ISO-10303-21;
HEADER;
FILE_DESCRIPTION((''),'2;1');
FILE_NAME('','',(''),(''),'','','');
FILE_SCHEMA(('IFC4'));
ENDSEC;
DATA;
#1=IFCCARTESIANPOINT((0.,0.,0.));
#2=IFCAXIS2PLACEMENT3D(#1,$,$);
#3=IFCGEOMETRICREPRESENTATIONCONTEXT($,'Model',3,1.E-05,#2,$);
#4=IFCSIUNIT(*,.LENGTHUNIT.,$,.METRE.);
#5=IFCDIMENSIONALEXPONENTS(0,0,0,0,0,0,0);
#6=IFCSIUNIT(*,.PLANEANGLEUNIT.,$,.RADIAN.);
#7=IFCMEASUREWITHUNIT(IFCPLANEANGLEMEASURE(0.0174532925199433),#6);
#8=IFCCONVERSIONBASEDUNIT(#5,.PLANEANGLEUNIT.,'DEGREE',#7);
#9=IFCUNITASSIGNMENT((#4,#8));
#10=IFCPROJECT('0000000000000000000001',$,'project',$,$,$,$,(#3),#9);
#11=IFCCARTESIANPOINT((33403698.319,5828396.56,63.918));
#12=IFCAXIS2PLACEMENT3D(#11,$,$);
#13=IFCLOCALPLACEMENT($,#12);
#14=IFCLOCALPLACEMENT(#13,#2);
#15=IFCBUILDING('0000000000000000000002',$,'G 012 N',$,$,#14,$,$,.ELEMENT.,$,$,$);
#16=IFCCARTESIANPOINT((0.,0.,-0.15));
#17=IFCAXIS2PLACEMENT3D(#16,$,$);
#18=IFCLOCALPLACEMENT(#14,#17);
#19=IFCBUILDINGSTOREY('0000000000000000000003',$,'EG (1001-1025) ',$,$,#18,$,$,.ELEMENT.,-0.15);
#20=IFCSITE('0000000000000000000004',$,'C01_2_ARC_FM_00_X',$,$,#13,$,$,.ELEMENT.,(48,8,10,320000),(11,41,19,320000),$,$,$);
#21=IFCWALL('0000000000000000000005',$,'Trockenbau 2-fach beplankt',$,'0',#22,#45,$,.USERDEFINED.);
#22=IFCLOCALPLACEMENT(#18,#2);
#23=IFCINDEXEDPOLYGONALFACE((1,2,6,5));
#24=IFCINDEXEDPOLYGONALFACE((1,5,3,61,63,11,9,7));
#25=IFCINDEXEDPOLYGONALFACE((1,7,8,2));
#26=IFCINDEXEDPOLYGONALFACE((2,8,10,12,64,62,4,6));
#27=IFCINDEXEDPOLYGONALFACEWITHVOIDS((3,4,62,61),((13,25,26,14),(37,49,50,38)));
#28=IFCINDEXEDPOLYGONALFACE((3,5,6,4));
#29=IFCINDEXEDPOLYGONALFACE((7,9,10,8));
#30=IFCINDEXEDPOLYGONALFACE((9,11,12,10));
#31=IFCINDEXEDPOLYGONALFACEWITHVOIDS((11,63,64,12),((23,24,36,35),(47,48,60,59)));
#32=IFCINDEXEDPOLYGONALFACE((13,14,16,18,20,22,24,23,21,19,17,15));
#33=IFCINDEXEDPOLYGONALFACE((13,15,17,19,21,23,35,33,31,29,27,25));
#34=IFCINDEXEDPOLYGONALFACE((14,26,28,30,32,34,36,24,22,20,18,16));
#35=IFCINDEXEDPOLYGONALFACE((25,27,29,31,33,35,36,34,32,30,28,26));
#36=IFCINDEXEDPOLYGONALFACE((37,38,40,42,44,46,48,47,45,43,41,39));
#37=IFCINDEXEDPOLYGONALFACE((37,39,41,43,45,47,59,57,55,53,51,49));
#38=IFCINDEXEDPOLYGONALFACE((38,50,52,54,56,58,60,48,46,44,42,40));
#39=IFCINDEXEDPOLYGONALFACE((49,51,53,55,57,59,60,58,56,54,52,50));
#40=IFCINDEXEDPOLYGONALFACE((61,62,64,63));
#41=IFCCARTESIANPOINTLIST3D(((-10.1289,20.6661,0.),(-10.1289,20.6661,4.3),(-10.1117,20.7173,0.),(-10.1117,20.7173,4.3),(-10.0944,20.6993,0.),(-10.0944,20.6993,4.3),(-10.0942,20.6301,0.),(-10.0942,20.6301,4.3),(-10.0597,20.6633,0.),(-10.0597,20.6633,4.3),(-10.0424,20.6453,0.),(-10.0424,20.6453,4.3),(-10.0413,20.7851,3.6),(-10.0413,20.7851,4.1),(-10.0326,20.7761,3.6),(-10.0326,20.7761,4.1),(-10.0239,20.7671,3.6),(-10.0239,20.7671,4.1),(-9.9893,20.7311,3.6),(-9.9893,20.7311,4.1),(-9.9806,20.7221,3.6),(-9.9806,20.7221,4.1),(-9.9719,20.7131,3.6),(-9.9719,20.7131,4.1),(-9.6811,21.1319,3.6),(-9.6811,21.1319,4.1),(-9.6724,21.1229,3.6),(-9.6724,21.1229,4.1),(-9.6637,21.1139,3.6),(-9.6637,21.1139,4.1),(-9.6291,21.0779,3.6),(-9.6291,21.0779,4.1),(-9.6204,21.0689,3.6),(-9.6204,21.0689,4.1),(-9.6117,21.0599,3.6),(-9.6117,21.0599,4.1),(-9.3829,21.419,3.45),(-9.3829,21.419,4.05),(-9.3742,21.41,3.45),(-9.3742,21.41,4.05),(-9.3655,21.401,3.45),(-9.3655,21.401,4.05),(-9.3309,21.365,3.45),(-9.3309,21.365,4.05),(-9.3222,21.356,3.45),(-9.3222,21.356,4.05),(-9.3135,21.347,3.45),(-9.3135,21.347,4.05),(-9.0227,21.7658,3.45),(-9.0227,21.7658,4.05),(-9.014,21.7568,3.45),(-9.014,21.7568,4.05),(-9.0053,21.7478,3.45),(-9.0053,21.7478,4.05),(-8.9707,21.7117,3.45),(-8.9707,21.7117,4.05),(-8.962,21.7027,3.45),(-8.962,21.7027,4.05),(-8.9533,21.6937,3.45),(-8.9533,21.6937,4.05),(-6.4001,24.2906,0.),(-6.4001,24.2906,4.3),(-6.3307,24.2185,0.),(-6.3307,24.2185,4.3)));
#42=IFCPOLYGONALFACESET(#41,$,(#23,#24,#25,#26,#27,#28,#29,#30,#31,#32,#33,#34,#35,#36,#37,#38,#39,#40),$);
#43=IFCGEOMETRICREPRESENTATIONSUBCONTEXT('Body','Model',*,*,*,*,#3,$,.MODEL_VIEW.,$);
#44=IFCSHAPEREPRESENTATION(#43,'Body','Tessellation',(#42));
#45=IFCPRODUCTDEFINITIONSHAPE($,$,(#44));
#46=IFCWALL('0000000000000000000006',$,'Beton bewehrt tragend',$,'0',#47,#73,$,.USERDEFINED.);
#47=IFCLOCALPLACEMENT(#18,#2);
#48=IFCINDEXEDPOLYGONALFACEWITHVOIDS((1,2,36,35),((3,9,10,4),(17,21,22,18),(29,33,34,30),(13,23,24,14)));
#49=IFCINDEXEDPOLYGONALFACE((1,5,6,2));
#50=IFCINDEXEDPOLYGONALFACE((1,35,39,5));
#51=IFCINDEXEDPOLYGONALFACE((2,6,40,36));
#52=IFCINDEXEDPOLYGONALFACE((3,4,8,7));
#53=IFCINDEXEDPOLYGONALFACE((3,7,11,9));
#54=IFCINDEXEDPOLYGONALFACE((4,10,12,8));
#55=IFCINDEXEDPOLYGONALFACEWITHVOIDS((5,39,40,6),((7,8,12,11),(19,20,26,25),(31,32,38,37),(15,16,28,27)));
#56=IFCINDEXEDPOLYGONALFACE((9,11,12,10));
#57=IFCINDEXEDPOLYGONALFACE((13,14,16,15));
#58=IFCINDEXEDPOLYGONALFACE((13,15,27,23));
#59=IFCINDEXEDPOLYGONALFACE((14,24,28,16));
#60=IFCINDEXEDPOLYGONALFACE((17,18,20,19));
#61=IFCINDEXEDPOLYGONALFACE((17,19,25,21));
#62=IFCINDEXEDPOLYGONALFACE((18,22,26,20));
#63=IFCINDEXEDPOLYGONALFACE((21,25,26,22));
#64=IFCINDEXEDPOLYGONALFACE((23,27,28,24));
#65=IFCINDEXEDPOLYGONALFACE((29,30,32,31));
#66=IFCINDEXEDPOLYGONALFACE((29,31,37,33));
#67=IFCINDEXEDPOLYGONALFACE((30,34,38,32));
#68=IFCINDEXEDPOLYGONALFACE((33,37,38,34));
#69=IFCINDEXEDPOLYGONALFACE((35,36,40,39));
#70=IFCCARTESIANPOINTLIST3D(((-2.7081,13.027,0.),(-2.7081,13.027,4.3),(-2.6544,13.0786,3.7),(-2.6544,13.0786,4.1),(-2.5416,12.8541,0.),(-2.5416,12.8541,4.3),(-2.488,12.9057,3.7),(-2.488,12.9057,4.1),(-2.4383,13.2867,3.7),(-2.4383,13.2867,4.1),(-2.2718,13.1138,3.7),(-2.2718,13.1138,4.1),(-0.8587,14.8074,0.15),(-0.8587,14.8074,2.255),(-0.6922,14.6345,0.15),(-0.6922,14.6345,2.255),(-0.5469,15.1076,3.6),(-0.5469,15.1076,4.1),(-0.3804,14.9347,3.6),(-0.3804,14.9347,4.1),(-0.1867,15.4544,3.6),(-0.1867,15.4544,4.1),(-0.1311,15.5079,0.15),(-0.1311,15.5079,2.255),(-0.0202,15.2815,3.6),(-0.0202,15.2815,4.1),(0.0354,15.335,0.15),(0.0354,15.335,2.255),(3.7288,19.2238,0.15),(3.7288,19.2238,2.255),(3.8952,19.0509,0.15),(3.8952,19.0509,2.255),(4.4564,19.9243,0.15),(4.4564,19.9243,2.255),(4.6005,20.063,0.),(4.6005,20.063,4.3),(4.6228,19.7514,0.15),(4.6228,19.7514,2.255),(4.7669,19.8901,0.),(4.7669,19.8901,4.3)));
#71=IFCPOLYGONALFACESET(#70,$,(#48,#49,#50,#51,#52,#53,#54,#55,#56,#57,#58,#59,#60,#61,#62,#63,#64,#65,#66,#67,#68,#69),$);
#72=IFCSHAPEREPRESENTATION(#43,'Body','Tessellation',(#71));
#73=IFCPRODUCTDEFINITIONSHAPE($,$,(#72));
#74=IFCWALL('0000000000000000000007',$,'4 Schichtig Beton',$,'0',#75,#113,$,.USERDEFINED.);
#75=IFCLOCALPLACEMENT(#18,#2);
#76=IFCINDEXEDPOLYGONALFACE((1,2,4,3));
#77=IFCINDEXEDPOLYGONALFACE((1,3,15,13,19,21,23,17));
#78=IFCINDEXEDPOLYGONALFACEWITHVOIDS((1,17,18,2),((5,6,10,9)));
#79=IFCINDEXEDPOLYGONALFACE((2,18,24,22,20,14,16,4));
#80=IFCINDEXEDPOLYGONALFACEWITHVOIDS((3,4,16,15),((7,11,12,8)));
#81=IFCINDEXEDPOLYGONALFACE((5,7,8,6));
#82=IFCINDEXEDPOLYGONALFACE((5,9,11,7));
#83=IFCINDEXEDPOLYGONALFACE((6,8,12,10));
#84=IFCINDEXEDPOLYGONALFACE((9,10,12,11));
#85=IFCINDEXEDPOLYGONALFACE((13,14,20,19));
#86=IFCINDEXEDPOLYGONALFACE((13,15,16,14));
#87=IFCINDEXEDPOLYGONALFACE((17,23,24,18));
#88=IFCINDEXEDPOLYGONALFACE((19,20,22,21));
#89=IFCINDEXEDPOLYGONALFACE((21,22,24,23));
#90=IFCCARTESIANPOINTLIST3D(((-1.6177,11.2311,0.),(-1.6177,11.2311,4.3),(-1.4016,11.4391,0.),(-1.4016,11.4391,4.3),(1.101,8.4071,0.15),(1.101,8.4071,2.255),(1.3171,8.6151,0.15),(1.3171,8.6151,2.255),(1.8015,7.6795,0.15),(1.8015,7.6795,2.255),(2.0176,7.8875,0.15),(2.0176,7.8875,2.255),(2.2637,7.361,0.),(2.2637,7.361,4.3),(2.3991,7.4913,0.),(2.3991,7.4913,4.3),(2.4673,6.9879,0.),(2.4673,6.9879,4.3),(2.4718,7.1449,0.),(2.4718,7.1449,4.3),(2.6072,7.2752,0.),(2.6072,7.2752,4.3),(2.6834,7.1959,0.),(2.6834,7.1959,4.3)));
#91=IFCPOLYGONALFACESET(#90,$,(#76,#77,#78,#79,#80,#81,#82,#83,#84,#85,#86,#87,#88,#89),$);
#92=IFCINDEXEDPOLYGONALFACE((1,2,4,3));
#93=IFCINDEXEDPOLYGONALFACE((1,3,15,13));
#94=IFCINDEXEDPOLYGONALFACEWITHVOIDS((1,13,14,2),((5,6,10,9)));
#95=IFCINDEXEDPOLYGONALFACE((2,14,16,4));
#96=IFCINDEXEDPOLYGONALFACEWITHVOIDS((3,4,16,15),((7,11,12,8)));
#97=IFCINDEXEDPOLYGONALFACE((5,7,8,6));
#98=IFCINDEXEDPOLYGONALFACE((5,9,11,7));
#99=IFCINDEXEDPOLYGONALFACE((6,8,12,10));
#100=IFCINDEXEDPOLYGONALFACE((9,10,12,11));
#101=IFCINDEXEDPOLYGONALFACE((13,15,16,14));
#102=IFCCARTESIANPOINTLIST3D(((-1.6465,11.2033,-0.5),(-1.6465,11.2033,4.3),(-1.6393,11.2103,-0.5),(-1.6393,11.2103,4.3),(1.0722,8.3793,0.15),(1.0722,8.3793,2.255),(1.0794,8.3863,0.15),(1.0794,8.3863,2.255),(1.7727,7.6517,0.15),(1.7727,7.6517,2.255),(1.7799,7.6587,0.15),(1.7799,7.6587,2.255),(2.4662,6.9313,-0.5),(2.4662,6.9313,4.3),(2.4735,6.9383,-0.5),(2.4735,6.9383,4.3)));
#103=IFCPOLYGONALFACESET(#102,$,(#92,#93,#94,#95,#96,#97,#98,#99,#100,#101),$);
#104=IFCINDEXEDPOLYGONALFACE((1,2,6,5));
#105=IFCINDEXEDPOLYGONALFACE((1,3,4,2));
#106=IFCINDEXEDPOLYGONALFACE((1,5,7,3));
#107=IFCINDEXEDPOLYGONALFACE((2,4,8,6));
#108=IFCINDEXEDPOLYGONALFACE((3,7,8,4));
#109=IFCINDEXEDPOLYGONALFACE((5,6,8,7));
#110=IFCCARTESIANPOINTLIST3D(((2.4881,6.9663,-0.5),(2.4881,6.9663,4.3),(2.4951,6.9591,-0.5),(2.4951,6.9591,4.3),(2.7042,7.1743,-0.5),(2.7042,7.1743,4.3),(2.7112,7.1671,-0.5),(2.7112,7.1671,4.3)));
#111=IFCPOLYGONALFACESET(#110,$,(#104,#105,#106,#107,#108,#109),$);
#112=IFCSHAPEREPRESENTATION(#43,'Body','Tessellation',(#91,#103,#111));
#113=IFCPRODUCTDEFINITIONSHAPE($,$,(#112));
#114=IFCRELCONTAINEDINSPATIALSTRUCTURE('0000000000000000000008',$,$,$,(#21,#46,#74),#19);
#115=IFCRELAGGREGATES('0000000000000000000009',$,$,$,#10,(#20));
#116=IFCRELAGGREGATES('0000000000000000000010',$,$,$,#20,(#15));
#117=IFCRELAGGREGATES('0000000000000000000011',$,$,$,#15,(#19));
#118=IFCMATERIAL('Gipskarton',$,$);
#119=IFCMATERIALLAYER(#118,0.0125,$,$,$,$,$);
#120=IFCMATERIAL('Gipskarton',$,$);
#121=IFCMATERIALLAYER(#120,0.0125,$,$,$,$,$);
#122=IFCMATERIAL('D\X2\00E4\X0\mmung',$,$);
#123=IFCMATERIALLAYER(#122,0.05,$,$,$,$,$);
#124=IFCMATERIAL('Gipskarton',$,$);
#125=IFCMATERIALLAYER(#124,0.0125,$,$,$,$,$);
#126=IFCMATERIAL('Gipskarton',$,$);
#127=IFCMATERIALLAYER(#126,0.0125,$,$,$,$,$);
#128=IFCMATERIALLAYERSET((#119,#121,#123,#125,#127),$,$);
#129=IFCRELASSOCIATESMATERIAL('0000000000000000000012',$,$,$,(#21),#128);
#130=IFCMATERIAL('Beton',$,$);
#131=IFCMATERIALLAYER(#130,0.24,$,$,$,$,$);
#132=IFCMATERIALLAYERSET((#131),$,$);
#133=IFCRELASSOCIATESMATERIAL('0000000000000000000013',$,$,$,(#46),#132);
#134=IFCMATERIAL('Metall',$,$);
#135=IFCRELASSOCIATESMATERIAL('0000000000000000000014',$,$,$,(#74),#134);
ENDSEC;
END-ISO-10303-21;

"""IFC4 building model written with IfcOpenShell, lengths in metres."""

from ifc_helpers import new_model, entity, si_unit, converted_unit, frame, frame_2d, origin, origin_with_axes, place, context, subcontext, project, spatial, polyline, rectangle, outline, extrude, clip, bounded_halfspace, material, layer, layer_set, layer_usage, element, save


model = new_model("IFC4")

# Units and contexts
model_context = context("Model", 3, precision=1e-05, world=origin())
body_context = subcontext(model_context, "Body", "Model", "MODEL_VIEW")
ifc_project = project(units=[si_unit("LENGTHUNIT", "METRE"), converted_unit("PLANEANGLEUNIT", "DEGREE", entity("IfcPlaneAngleMeasure", 0.0174532925199433), si_unit("PLANEANGLEUNIT", "RADIAN"), dimensions=[0, 0, 0, 0, 0, 0, 0])], contexts=[model_context])

# Site, building, storey
site_placement = place(None, frame((33403698.319, 5828396.56, 63.918)))
site = spatial("IfcSite", under=ifc_project, at=site_placement, Name="C01_2_ARC_FM_00_X", CompositionType="ELEMENT", RefLatitude=(48, 8, 10, 320000), RefLongitude=(11, 41, 19, 320000))
building_placement = place(site_placement, origin())
building = spatial("IfcBuilding", under=site, at=building_placement, Name="G 012 N", CompositionType="ELEMENT")
storey_placement = place(building_placement, frame((0.0, 0.0, -0.15)))
storey = spatial("IfcBuildingStorey", under=building, at=storey_placement, Name="EG (1001-1025) ", CompositionType="ELEMENT", Elevation=-0.15)

# Walls, openings
ifc_material_1 = material(Name="Gipskarton")
ifc_layer_1 = layer(ifc_material_1, 0.0125)
ifc_material_2 = material(Name="Gipskarton")
ifc_layer_2 = layer(ifc_material_2, 0.0125)
ifc_material_3 = material(Name="Dämmung")
ifc_layer_3 = layer(ifc_material_3, 0.05)
ifc_material_4 = material(Name="Gipskarton")
ifc_layer_4 = layer(ifc_material_4, 0.0125)
ifc_material_5 = material(Name="Gipskarton")
ifc_layer_5 = layer(ifc_material_5, 0.0125)
ifc_layer_set_1 = layer_set([ifc_layer_1, ifc_layer_2, ifc_layer_3, ifc_layer_4, ifc_layer_5])
ifc_layer_usage_1 = layer_usage(ifc_layer_set_1, "AXIS2", "POSITIVE", 0.0)
wall_1_placement = place(storey_placement, frame((-10.0424, 20.6453, 0.0), z_axis=(0.0, 0.0, 1.0), x_axis=(0.720408, 0.693551, 0.0)))
wall_1 = element("IfcWall", 1, at=wall_1_placement, inside=storey, material=ifc_layer_usage_1, Name="Trockenbau 2-fach beplankt", ObjectType="0", PredefinedType="USERDEFINED", context=body_context, shape_type="SweptSolid", body=[
    extrude(outline(polyline([(0.0728, 0.0509), (0.0728, 0.0259), (0.025, 0.0259), (0.025, -0.0241), (0.0728, -0.0241), (0.0728, -0.0491), (5.225, -0.0491), (5.225, 0.0509), (0.0728, 0.0509)])), frame((-0.0728, 0.0491, 0.0), z_axis=(0.0, 0.0, 1.0), x_axis=(1.0, 0.0, 0.0)), (0.0, 0.0, 1.0), 4.3),
])
opening_1_placement = place(wall_1_placement, frame((1.5117, 0.1, 3.45), z_axis=(0.0, -1.0, 0.0), x_axis=(0.0, 0.0, 1.0)))
element("IfcOpeningElement", 2, at=opening_1_placement, cuts=wall_1, ObjectType="Opening", context=body_context, shape_type="SweptSolid", body=[
    extrude(outline(polyline([(0.0, 0.5), (0.6, 0.5), (0.6, 0.0), (0.0, 0.0), (0.0, 0.5)])), origin_with_axes(), (0.0, 0.0, 1.0), 0.0125),
    extrude(outline(polyline([(0.0, 0.5), (0.6, 0.5), (0.6, 0.0), (0.0, 0.0), (0.0, 0.5)])), frame((0.0, 0.0, 0.0125), z_axis=(0.0, 0.0, 1.0), x_axis=(1.0, 0.0, 0.0)), (0.0, 0.0, 1.0), 0.0125),
    extrude(outline(polyline([(0.0, 0.5), (0.6, 0.5), (0.6, 0.0), (0.0, 0.0), (0.0, 0.5)])), frame((0.0, 0.0, 0.025), z_axis=(0.0, 0.0, 1.0), x_axis=(1.0, 0.0, 0.0)), (0.0, 0.0, 1.0), 0.05),
    extrude(outline(polyline([(0.0, 0.5), (0.6, 0.5), (0.6, 0.0), (0.0, 0.0), (0.0, 0.5)])), frame((0.0, 0.0, 0.075), z_axis=(0.0, 0.0, 1.0), x_axis=(1.0, 0.0, 0.0)), (0.0, 0.0, 1.0), 0.0125),
    extrude(outline(polyline([(0.0, 0.5), (0.6, 0.5), (0.6, 0.0), (0.0, 0.0), (0.0, 0.5)])), frame((0.0, 0.0, 0.0875), z_axis=(0.0, 0.0, 1.0), x_axis=(1.0, 0.0, 0.0)), (0.0, 0.0, 1.0), 0.0125),
])
opening_2_placement = place(wall_1_placement, frame((0.0978, 0.0, 3.6), z_axis=(0.0, 1.0, 0.0), x_axis=(0.0, 0.0, 1.0)))
element("IfcOpeningElement", 3, at=opening_2_placement, cuts=wall_1, ObjectType="Opening", context=body_context, shape_type="SweptSolid", body=[
    extrude(outline(polyline([(0.0, 0.5), (0.5, 0.5), (0.5, 0.0), (0.0, 0.0), (0.0, 0.5)])), origin_with_axes(), (0.0, 0.0, 1.0), 0.0125),
    extrude(outline(polyline([(0.0, 0.5), (0.5, 0.5), (0.5, 0.0), (0.0, 0.0), (0.0, 0.5)])), frame((0.0, 0.0, 0.0125), z_axis=(0.0, 0.0, 1.0), x_axis=(1.0, 0.0, 0.0)), (0.0, 0.0, 1.0), 0.0125),
    extrude(outline(polyline([(0.0, 0.5), (0.5, 0.5), (0.5, 0.0), (0.0, 0.0), (0.0, 0.5)])), frame((0.0, 0.0, 0.025), z_axis=(0.0, 0.0, 1.0), x_axis=(1.0, 0.0, 0.0)), (0.0, 0.0, 1.0), 0.05),
    extrude(outline(polyline([(0.0, 0.5), (0.5, 0.5), (0.5, 0.0), (0.0, 0.0), (0.0, 0.5)])), frame((0.0, 0.0, 0.075), z_axis=(0.0, 0.0, 1.0), x_axis=(1.0, 0.0, 0.0)), (0.0, 0.0, 1.0), 0.0125),
    extrude(outline(polyline([(0.0, 0.5), (0.5, 0.5), (0.5, 0.0), (0.0, 0.0), (0.0, 0.5)])), frame((0.0, 0.0, 0.0875), z_axis=(0.0, 0.0, 1.0), x_axis=(1.0, 0.0, 0.0)), (0.0, 0.0, 1.0), 0.0125),
])
ifc_material_6 = material(Name="Beton")
ifc_layer_6 = layer(ifc_material_6, 0.24)
ifc_layer_set_2 = layer_set([ifc_layer_6])
ifc_layer_usage_2 = layer_usage(ifc_layer_set_2, "AXIS2", "POSITIVE", 0.0)
wall_2_placement = place(storey_placement, frame((4.6005, 20.063, 0.0), z_axis=(0.0, 0.0, 1.0), x_axis=(-0.720408, -0.693551, 0.0)))
wall_2 = element("IfcWall", 4, at=wall_2_placement, inside=storey, material=ifc_layer_usage_2, Name="Beton bewehrt tragend", ObjectType="0", PredefinedType="USERDEFINED", context=body_context, shape_type="SweptSolid", body=[
    extrude(rectangle(XDim=10.145, YDim=0.24, at=frame_2d((5.0725, 0.12), x_axis=(1.0, 0.0))), origin_with_axes(), (0.0, 0.0, 1.0), 4.3),
])
opening_3_placement = place(wall_2_placement, frame((0.2, 0.0, 0.15), z_axis=(0.0, 1.0, 0.0), x_axis=(0.0, 0.0, 1.0)))
element("IfcOpeningElement", 5, at=opening_3_placement, cuts=wall_2, ObjectType="Opening", context=body_context, shape_type="SweptSolid", body=[
    extrude(outline(polyline([(0.0, 1.01), (2.105, 1.01), (2.105, 0.0), (0.0, 0.0), (0.0, 1.01)])), origin_with_axes(), (0.0, 0.0, 1.0), 0.24),
])
opening_4_placement = place(wall_2_placement, frame((6.645, 0.0, 3.6), z_axis=(0.0, 1.0, 0.0), x_axis=(0.0, 0.0, 1.0)))
element("IfcOpeningElement", 6, at=opening_4_placement, cuts=wall_2, ObjectType="Opening", context=body_context, shape_type="SweptSolid", body=[
    extrude(outline(polyline([(0.0, 0.5), (0.5, 0.5), (0.5, 0.0), (0.0, 0.0), (0.0, 0.5)])), origin_with_axes(), (0.0, 0.0, 1.0), 0.24),
])
opening_5_placement = place(wall_2_placement, frame((6.5679, 0.0, 0.15), z_axis=(0.0, 1.0, 0.0), x_axis=(0.0, 0.0, 1.0)))
element("IfcOpeningElement", 7, at=opening_5_placement, cuts=wall_2, ObjectType="Opening", context=body_context, shape_type="SweptSolid", body=[
    extrude(outline(polyline([(0.0, 1.01), (2.105, 1.01), (2.105, 0.0), (0.0, 0.0), (0.0, 1.01)])), origin_with_axes(), (0.0, 0.0, 1.0), 0.24),
])
opening_6_placement = place(wall_2_placement, frame((10.0705, 0.24, 3.7), z_axis=(0.0, -1.0, 0.0), x_axis=(0.0, 0.0, 1.0)))
element("IfcOpeningElement", 8, at=opening_6_placement, cuts=wall_2, ObjectType="Opening", context=body_context, shape_type="SweptSolid", body=[
    extrude(outline(polyline([(0.0, 0.3), (0.4, 0.3), (0.4, 0.0), (0.0, 0.0), (0.0, 0.3)])), origin_with_axes(), (0.0, 0.0, 1.0), 0.24),
])

# Wall, opening
ifc_material_7 = material(Name="Metall")
wall_3_placement = place(storey_placement, frame((-1.6465, 11.2033, -0.5), z_axis=(0.0, 0.0, 1.0), x_axis=(0.693551, -0.720408, 0.0)))
wall_3 = element("IfcWall", 9, at=wall_3_placement, inside=storey, material=ifc_material_7, Name="4 Schichtig Beton", ObjectType="0", PredefinedType="USERDEFINED", context=body_context, shape_type="Clipping", body=[
    clip(extrude(outline(polyline([(-3.0568, 2.9429), (2.8332, 2.9429), (2.8332, 3.2429), (2.7232, 3.2429), (2.7232, 3.055), (2.4232, 3.055), (2.4232, 3.2429), (-3.0568, 3.2429), (-3.0568, 2.9429)])), frame((3.0568, -2.9029, 0.0), z_axis=(0.0, 0.0, 1.0), x_axis=(1.0, 0.0, 0.0)), (0.0, 0.0, 1.0), 4.8), bounded_halfspace(frame((4.2875, 0.218, 0.5), z_axis=(0.0, 0.0, 1.0), x_axis=(1.0, 0.0, 0.0)), True, origin_with_axes(), polyline([(0.0, 0.04), (5.89, 0.04), (5.89, 0.34), (5.78, 0.34), (5.78, 0.1521), (5.48, 0.1521), (5.48, 0.34), (0.0, 0.34), (0.0, 0.04)]))),
    clip(extrude(rectangle(XDim=0.01, YDim=5.93, at=frame_2d((2.965, -0.005), x_axis=(0.0, -1.0))), frame((0.0, 0.01, 0.0), z_axis=(0.0, 0.0, 1.0), x_axis=(1.0, 0.0, 0.0)), (0.0, 0.0, 1.0), 4.8), bounded_halfspace(frame((4.2875, 0.218, 0.5), z_axis=(0.0, 0.0, 1.0), x_axis=(1.0, 0.0, 0.0)), True, origin_with_axes(), polyline([(0.0, 0.04), (5.89, 0.04), (5.89, 0.34), (5.78, 0.34), (5.78, 0.1521), (5.48, 0.1521), (5.48, 0.34), (0.0, 0.34), (0.0, 0.04)]))),
    clip(extrude(rectangle(XDim=0.01, YDim=0.3, at=frame_2d((-0.005, -0.15), x_axis=(-1.0, 0.0))), frame((5.93, 0.34, 0.0), z_axis=(0.0, 0.0, 1.0), x_axis=(1.0, 0.0, 0.0)), (0.0, 0.0, 1.0), 4.8), bounded_halfspace(frame((4.2875, 0.218, 0.5), z_axis=(0.0, 0.0, 1.0), x_axis=(1.0, 0.0, 0.0)), True, origin_with_axes(), polyline([(0.0, 0.04), (5.89, 0.04), (5.89, 0.34), (5.78, 0.34), (5.78, 0.1521), (5.48, 0.1521), (5.48, 0.34), (0.0, 0.34), (0.0, 0.04)]))),
])
opening_7_placement = place(wall_3_placement, frame((3.92, 0.0, 0.65), z_axis=(0.0, 1.0, 0.0), x_axis=(0.0, 0.0, 1.0)))
element("IfcOpeningElement", 10, at=opening_7_placement, cuts=wall_3, ObjectType="Opening", context=body_context, shape_type="SweptSolid", body=[
    extrude(outline(polyline([(0.0, 1.01), (2.105, 1.01), (2.105, 0.0), (0.0, 0.0), (0.0, 1.01)])), origin_with_axes(), (0.0, 0.0, 1.0), 0.01),
    extrude(outline(polyline([(0.0, 1.01), (2.105, 1.01), (2.105, 0.0), (0.0, 0.0), (0.0, 1.01)])), frame((0.0, 0.0, 0.01), z_axis=(0.0, 0.0, 1.0), x_axis=(1.0, 0.0, 0.0)), (0.0, 0.0, 1.0), 0.03),
    extrude(outline(polyline([(0.0, 1.01), (2.105, 1.01), (2.105, 0.0), (0.0, 0.0), (0.0, 1.01)])), frame((0.0, 0.0, 0.04), z_axis=(0.0, 0.0, 1.0), x_axis=(1.0, 0.0, 0.0)), (0.0, 0.0, 1.0), 0.3),
])

save(model, "model.ifc")
